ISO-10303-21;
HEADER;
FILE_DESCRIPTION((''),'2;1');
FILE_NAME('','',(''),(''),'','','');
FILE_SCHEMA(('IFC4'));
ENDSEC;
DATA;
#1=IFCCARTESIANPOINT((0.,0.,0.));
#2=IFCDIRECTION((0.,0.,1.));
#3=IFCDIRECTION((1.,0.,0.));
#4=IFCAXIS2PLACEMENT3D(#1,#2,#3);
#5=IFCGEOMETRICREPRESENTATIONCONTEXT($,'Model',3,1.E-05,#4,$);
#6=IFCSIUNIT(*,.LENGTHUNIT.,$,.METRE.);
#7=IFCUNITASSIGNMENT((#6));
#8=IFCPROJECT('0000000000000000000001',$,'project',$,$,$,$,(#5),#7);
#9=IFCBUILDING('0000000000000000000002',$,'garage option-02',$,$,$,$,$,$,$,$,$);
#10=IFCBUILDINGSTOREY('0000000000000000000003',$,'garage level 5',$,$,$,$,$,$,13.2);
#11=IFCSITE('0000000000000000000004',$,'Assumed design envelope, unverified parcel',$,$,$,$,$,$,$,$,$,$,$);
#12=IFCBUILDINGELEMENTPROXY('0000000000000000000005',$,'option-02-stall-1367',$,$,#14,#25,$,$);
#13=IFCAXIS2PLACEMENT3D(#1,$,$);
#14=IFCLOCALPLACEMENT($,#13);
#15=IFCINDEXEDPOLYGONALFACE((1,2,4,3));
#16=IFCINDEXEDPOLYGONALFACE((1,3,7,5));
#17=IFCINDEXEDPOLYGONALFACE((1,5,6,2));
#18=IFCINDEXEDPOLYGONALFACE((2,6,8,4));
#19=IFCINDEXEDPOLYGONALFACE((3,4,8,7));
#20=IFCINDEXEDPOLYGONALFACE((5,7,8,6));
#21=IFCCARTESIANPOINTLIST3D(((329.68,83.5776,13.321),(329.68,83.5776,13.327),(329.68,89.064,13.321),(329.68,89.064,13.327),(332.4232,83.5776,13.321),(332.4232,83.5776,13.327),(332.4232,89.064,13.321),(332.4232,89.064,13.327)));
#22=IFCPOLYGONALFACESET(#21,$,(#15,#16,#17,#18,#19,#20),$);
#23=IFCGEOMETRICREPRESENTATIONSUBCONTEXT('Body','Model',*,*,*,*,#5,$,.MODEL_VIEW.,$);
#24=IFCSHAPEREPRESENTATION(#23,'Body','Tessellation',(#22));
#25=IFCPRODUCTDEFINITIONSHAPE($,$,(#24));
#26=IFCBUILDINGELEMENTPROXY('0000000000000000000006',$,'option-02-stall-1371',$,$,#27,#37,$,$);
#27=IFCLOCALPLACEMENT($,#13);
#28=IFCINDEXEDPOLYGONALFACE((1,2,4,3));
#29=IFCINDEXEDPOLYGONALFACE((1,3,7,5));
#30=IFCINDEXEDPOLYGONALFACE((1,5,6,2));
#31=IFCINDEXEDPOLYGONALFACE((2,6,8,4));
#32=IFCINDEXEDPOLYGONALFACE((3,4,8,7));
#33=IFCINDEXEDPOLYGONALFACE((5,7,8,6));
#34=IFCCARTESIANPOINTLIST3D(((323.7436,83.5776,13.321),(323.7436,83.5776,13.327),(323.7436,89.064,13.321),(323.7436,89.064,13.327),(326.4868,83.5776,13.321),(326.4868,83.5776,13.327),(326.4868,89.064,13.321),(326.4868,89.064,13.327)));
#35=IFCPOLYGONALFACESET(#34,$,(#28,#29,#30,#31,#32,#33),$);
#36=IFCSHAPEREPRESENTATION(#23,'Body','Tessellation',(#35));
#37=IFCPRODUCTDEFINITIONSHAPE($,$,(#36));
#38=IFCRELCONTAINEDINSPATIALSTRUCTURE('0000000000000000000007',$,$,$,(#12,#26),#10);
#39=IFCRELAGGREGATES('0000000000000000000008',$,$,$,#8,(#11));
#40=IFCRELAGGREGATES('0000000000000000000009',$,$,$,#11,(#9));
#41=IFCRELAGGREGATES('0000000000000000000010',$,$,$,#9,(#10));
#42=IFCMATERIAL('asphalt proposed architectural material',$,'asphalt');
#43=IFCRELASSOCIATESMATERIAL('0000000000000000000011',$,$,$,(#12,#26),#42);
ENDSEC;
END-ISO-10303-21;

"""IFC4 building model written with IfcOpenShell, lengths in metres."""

from ifc_helpers import new_model, si_unit, frame, origin_with_axes, place, context, subcontext, project, spatial, rectangle, extrude, material, element, save


model = new_model("IFC4")

# Units and contexts
model_context = context("Model", 3, precision=1e-05, world=origin_with_axes())
body_context = subcontext(model_context, "Body", "Model", "MODEL_VIEW")
ifc_project = project(units=[si_unit("LENGTHUNIT", "METRE")], contexts=[model_context])

# Site, building, storey
site = spatial("IfcSite", under=ifc_project, Name="Assumed design envelope, unverified parcel")
building = spatial("IfcBuilding", under=site, Name="garage option-02")
storey = spatial("IfcBuildingStorey", under=building, Name="garage level 5", Elevation=13.2)

# Building element proxies
ifc_material = material(Name="asphalt proposed architectural material", Category="asphalt")
for number, where, z_axis, x_axis, name in (
    (1, (331.0516, 86.3208, 13.321), (0.0, 0.0, 1.0), (1.0, 0.0, 0.0), "option-02-stall-1367"),
    (2, (325.1152, 86.3208, 13.321), (0.0, 0.0, 1.0), (1.0, 0.0, 0.0), "option-02-stall-1371"),
):
    element("IfcBuildingElementProxy", number, at=place(None, frame(where, z_axis=z_axis, x_axis=x_axis)), inside=storey, material=ifc_material, Name=name, context=body_context, shape_type="SweptSolid", body=[
        extrude(rectangle(XDim=2.7432, YDim=5.4864), origin_with_axes(), (0.0, 0.0, 1.0), 0.006),
    ])

save(model, "model.ifc")
